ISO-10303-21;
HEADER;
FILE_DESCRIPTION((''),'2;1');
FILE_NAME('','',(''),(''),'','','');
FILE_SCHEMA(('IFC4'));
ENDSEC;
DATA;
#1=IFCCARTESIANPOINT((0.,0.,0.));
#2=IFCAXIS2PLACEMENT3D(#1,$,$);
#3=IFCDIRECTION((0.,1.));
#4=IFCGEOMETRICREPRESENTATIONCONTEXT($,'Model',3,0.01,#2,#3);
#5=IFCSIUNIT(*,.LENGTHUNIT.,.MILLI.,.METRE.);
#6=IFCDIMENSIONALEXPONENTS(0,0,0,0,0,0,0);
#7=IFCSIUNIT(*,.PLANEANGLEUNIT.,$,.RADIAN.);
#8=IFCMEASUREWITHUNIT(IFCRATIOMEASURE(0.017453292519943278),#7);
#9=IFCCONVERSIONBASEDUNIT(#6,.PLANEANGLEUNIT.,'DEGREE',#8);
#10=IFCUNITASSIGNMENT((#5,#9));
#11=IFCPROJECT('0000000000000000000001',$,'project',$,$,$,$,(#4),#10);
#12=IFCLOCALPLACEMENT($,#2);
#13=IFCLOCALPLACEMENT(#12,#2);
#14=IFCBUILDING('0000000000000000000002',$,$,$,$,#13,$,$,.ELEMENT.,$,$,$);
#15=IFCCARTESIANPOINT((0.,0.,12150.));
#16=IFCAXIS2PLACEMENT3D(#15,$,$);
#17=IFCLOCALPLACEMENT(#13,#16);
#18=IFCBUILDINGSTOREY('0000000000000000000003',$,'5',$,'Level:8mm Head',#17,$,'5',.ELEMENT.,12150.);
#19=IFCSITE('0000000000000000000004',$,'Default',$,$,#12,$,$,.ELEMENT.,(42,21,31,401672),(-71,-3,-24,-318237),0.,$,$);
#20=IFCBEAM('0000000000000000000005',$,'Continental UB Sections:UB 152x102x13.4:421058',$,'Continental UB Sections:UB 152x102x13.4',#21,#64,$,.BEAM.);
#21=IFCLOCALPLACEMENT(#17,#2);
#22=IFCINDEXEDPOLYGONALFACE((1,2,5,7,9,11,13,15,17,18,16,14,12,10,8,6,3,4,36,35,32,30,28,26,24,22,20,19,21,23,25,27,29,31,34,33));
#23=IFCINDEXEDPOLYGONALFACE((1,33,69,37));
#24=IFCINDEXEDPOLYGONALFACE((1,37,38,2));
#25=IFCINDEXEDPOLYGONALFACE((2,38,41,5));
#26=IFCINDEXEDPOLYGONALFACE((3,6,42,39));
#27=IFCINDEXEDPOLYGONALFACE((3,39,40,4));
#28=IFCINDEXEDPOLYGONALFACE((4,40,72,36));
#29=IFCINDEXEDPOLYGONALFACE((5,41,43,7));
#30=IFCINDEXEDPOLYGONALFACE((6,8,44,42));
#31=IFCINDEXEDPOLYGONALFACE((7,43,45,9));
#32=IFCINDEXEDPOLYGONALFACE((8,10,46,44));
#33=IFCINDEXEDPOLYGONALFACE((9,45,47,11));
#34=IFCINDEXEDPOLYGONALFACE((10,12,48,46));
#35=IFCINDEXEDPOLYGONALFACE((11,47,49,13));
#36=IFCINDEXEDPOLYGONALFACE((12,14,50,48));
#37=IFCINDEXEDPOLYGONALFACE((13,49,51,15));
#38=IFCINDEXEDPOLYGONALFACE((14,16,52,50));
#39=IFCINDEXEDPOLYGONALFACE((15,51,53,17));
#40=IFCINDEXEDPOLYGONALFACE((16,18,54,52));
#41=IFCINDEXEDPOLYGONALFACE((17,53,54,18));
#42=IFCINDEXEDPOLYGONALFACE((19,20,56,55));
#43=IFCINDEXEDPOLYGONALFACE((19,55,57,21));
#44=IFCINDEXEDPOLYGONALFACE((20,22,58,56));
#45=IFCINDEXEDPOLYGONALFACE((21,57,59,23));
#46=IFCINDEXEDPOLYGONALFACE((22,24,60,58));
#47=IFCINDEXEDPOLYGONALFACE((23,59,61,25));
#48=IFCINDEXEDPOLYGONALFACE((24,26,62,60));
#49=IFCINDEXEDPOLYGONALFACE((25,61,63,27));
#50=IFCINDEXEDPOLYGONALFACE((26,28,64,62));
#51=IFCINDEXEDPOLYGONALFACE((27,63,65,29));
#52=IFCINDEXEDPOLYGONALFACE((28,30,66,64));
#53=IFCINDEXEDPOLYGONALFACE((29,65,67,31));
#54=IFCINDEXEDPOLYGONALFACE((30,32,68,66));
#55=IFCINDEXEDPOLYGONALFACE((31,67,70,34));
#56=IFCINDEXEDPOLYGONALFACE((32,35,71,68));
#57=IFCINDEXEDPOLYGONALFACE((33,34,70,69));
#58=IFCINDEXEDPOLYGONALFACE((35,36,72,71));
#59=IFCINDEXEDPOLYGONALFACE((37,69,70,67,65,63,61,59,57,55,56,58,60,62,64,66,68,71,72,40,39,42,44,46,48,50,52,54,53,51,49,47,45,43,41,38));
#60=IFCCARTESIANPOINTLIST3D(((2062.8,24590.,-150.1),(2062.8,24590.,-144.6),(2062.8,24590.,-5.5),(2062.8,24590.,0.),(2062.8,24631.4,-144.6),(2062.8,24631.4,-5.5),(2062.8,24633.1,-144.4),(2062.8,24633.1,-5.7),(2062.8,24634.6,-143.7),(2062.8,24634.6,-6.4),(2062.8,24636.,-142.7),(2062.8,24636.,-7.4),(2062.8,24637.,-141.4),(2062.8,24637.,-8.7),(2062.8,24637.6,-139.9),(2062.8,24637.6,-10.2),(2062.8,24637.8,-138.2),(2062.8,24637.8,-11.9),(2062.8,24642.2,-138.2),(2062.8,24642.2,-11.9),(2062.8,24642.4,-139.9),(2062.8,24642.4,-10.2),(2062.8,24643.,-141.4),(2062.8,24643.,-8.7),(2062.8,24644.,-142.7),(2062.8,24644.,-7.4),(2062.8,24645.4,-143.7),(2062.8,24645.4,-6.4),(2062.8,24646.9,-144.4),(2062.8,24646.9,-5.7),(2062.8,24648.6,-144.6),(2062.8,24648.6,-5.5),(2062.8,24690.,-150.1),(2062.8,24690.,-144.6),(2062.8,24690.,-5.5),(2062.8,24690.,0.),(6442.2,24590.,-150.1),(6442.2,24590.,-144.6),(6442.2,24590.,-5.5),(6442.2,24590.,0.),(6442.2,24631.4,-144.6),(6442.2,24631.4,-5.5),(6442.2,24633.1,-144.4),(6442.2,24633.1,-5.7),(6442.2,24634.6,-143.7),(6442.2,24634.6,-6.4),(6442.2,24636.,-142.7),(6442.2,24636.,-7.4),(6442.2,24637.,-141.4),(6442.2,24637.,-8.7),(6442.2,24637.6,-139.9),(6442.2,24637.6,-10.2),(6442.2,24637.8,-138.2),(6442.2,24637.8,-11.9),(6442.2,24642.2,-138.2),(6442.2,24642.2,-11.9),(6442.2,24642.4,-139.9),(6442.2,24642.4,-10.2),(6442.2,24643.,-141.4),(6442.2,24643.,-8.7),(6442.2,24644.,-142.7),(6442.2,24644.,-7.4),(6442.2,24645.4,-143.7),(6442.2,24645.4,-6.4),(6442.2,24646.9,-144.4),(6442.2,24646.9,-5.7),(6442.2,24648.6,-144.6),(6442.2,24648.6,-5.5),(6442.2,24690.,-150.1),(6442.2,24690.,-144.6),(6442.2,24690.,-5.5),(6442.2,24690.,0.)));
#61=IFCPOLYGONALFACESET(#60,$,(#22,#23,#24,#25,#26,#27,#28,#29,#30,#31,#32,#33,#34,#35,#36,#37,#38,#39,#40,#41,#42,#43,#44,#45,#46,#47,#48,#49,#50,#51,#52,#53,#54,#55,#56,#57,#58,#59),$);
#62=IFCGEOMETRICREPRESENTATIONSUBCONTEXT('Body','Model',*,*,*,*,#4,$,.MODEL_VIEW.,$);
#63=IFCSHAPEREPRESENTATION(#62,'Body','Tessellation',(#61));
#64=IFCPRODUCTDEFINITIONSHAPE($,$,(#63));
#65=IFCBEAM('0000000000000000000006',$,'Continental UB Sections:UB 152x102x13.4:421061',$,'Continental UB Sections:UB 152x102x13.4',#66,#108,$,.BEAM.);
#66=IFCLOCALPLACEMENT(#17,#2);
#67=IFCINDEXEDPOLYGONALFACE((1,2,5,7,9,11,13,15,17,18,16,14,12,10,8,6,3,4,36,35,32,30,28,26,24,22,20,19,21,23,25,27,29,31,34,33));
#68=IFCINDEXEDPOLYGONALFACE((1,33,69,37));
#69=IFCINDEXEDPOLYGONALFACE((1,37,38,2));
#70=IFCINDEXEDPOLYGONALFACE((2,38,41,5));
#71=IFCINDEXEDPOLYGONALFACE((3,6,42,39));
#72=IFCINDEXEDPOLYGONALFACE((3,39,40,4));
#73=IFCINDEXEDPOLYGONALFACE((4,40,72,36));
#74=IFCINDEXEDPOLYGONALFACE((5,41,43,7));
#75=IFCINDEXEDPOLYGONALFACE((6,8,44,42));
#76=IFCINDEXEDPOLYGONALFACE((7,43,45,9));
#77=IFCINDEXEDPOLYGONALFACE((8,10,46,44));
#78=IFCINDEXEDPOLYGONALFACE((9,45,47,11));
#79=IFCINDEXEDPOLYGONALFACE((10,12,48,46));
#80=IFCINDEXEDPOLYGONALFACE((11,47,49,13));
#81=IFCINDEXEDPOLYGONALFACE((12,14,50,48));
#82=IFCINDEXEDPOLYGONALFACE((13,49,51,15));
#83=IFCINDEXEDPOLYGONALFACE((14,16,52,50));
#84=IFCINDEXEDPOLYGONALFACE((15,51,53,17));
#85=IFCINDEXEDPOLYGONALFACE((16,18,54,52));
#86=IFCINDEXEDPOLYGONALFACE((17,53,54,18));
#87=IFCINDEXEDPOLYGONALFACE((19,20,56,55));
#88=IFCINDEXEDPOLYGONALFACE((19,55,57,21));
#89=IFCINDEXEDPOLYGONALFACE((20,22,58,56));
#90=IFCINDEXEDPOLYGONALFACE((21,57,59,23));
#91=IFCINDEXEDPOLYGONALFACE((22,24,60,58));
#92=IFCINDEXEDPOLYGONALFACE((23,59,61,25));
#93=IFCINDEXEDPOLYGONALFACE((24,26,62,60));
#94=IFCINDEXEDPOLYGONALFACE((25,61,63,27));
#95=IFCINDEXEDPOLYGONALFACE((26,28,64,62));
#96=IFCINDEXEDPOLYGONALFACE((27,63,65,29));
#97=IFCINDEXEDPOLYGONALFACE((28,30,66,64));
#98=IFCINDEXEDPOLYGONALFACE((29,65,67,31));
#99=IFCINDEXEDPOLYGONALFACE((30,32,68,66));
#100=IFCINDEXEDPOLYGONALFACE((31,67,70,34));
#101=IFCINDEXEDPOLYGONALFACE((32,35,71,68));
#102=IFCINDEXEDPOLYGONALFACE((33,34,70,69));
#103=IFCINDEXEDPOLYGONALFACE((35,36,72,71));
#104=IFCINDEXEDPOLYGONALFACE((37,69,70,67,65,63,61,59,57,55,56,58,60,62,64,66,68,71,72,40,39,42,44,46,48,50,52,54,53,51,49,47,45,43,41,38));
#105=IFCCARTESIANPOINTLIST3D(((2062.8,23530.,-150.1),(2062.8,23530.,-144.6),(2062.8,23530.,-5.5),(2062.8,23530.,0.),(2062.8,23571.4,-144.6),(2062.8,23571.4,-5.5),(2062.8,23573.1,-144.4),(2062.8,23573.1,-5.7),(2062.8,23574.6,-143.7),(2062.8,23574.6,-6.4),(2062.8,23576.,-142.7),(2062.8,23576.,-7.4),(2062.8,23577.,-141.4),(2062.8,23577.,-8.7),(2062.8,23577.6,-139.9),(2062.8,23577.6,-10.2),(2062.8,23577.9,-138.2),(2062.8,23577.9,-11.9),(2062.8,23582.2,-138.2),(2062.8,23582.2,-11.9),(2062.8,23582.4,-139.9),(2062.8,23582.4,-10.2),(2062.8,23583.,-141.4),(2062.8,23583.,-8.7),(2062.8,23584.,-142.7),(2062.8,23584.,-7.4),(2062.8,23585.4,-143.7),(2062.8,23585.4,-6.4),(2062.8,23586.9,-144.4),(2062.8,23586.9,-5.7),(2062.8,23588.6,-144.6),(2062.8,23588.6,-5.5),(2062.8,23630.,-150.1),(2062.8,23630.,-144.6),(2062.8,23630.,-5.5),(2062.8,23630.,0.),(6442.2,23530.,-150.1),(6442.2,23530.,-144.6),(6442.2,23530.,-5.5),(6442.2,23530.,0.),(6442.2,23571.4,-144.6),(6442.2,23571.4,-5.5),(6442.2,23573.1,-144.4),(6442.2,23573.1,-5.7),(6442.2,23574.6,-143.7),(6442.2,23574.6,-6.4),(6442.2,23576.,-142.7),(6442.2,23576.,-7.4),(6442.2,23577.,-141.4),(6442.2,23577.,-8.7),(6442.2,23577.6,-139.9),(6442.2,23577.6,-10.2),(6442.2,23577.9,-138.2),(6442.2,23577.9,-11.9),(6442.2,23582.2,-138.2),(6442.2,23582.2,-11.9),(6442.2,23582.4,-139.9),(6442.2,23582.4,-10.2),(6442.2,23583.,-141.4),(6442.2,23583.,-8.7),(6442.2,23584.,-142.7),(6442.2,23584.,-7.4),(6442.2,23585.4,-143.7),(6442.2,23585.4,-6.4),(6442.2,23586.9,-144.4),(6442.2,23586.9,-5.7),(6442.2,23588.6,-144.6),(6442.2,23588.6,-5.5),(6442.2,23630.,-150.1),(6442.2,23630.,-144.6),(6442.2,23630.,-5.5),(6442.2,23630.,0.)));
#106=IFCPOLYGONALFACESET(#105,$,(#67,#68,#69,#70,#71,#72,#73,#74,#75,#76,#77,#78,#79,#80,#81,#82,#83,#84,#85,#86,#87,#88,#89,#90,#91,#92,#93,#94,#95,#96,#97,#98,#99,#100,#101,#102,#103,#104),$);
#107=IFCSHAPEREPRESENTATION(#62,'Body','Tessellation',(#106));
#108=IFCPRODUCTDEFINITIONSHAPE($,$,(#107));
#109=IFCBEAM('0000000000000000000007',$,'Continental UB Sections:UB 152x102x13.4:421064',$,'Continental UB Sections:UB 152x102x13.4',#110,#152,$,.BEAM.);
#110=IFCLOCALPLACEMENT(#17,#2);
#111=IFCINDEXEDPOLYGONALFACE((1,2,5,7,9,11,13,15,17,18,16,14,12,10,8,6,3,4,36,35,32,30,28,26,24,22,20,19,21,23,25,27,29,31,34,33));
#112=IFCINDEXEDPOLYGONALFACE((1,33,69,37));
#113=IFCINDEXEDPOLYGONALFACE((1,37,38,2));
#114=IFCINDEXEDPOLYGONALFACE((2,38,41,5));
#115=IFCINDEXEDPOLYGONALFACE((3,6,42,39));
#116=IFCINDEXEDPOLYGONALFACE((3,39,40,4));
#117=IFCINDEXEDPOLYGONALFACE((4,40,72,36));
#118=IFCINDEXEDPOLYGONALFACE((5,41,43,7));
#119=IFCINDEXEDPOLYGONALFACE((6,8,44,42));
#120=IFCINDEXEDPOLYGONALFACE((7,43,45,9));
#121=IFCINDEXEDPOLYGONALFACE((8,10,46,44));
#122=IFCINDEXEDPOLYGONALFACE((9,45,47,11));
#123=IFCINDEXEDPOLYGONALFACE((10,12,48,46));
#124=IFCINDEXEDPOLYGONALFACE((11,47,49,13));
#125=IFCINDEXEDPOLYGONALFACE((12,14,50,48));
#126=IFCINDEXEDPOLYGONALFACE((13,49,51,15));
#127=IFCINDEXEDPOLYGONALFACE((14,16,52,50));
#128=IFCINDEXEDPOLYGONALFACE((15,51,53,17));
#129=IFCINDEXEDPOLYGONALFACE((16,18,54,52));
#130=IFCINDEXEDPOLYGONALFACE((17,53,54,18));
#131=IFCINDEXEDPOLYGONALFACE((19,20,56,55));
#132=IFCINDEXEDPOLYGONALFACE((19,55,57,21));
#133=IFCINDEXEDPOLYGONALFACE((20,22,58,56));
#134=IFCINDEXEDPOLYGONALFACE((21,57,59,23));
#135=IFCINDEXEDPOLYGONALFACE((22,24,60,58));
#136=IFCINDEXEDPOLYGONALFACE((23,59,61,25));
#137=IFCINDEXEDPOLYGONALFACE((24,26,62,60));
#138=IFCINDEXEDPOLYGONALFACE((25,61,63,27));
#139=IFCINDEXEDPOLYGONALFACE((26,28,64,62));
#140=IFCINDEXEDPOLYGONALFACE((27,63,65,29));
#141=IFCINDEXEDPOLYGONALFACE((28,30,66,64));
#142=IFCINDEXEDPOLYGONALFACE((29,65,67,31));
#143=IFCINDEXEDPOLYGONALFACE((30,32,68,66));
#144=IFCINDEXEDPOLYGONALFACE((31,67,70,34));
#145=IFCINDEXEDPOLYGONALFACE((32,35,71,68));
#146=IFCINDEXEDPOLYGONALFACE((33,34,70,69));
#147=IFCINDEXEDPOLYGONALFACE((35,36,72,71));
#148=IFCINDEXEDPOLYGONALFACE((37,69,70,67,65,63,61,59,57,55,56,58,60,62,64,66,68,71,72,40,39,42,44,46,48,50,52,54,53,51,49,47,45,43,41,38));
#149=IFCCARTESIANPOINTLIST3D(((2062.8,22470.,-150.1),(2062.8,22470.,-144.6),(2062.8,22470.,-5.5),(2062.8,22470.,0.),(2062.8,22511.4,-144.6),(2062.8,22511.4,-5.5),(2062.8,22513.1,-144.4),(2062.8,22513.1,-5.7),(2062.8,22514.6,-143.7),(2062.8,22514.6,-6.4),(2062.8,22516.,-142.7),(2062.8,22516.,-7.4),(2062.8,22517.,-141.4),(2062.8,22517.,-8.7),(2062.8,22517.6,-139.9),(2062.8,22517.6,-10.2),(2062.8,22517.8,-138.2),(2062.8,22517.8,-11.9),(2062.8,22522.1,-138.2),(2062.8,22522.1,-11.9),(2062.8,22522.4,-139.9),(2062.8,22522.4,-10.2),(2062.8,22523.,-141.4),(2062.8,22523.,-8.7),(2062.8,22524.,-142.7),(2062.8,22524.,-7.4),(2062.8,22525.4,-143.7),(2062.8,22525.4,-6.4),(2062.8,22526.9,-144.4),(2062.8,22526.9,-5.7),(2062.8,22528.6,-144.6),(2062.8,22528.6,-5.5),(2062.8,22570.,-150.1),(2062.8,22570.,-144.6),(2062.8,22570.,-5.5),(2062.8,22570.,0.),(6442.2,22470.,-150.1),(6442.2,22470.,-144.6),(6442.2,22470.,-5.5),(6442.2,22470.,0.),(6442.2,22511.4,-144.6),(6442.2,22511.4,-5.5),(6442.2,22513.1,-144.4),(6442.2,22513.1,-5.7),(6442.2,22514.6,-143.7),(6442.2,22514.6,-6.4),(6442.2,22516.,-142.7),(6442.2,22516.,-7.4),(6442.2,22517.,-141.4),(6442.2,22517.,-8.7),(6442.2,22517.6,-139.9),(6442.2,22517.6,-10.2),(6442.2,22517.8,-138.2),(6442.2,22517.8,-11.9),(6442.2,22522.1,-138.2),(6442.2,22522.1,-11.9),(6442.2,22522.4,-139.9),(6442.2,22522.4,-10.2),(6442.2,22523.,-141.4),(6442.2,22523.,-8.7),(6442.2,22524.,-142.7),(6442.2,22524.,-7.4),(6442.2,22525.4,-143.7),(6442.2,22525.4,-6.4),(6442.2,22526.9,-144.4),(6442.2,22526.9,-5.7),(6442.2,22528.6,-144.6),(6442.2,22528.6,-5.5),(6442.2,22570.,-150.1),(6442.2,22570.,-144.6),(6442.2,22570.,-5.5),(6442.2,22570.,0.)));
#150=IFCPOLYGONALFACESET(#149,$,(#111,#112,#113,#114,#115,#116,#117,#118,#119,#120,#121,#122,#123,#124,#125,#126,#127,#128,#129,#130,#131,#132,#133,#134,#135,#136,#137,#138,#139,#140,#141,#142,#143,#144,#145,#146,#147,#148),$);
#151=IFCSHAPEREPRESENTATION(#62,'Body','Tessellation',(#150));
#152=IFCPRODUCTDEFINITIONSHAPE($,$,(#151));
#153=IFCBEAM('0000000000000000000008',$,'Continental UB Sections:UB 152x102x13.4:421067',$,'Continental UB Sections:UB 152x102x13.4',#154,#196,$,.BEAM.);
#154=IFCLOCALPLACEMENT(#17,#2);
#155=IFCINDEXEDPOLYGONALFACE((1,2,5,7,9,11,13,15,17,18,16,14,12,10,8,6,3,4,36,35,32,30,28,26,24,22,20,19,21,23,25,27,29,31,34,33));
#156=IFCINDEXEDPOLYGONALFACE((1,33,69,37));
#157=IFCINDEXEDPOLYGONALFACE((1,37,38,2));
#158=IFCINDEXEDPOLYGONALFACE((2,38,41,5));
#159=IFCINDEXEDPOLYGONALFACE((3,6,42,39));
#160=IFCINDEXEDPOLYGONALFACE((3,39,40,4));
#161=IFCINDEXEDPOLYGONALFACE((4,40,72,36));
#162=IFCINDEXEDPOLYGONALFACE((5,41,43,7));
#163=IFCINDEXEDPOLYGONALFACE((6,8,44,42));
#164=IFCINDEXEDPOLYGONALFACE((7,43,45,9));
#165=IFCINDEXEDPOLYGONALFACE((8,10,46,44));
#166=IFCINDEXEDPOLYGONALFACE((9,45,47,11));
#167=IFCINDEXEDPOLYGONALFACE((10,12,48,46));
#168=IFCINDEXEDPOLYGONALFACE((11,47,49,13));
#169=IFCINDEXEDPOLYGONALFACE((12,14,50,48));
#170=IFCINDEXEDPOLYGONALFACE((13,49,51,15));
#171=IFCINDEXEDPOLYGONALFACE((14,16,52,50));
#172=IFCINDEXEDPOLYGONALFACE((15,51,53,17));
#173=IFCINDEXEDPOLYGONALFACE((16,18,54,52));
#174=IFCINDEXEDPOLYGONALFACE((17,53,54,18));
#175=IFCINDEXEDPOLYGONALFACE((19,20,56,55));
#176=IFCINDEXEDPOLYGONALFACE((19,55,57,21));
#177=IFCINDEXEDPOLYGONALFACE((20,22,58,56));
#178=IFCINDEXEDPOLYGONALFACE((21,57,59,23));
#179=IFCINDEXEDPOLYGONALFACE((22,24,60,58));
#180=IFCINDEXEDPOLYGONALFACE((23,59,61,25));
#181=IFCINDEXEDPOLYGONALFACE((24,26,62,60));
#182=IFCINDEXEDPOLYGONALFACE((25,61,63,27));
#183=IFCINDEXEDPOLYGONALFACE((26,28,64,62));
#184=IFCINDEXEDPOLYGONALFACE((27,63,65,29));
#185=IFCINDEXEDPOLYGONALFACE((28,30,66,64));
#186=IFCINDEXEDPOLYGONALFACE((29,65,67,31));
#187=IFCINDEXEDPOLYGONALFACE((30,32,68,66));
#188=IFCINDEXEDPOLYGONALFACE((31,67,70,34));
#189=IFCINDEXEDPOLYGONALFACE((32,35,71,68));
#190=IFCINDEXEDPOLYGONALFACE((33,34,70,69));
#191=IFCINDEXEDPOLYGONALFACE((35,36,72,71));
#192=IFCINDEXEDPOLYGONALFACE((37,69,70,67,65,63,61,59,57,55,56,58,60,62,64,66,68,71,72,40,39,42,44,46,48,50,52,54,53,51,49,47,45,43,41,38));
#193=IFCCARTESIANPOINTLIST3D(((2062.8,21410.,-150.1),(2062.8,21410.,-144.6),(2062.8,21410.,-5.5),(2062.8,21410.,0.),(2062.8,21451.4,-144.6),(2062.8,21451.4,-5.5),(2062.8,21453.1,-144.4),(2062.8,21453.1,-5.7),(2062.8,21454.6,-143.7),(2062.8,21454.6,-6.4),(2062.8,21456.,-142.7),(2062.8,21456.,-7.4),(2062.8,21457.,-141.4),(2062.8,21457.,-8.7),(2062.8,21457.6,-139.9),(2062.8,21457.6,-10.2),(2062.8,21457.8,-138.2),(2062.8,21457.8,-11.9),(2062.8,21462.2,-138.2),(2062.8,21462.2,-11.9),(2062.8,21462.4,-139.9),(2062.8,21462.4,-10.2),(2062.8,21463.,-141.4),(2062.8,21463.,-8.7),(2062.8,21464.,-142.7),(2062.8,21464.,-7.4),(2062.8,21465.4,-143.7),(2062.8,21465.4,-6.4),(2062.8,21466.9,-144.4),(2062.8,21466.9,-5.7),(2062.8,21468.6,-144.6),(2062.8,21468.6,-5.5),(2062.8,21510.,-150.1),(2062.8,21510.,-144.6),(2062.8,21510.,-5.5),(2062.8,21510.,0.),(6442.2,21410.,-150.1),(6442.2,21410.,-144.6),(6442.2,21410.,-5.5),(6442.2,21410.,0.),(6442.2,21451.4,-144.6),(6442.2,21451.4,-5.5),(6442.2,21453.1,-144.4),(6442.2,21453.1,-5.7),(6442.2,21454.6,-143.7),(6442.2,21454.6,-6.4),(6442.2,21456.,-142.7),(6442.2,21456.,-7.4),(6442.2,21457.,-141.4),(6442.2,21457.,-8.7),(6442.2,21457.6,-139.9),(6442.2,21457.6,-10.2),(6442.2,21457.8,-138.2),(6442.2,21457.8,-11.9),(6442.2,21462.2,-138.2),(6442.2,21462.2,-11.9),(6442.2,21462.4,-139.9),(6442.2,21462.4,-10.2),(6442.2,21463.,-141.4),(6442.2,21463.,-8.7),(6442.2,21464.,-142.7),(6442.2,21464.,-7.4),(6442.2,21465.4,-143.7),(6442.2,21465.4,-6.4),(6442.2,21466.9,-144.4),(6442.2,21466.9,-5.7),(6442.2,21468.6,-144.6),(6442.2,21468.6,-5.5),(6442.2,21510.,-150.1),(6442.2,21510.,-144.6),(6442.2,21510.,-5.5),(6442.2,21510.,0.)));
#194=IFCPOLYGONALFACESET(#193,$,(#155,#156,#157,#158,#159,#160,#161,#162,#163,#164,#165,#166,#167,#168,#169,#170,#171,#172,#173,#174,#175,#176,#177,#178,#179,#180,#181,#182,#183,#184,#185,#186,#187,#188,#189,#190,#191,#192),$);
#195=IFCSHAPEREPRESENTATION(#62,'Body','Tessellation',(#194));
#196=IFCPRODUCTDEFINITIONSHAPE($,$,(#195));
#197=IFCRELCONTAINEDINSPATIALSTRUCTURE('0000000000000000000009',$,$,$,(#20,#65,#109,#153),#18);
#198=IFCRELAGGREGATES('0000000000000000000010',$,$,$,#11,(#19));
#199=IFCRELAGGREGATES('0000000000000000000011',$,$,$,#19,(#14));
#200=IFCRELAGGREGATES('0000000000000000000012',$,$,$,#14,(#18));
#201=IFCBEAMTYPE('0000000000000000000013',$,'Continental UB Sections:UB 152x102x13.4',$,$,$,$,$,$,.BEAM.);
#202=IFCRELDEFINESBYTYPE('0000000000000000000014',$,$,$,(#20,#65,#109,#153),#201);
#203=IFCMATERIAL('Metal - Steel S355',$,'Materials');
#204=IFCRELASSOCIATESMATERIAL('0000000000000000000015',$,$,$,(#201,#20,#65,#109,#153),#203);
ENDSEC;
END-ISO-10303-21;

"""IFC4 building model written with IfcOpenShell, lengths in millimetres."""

from ifc_helpers import new_model, entity, si_unit, converted_unit, direction, frame, origin, place, context, subcontext, project, spatial, line, arc, indexed_curve, outline, extrude, source, transform, mapped, material, type_object, type_shapes, element, save


model = new_model("IFC4")

# Units and contexts
model_context = context("Model", 3, precision=0.01, world=origin(), true_north=direction((0.0, 1.0)))
body_context = subcontext(model_context, "Body", "Model", "MODEL_VIEW")
ifc_project = project(units=[si_unit("LENGTHUNIT", "METRE", prefix="MILLI"), converted_unit("PLANEANGLEUNIT", "DEGREE", entity("IfcRatioMeasure", 0.017453292519943278), si_unit("PLANEANGLEUNIT", "RADIAN"), dimensions=[0, 0, 0, 0, 0, 0, 0])], contexts=[model_context])

# Site, building, storey
site_placement = place(None, origin())
site = spatial("IfcSite", under=ifc_project, at=site_placement, Name="Default", CompositionType="ELEMENT", RefLatitude=(42, 21, 31, 401672), RefLongitude=(-71, -3, -24, -318237), RefElevation=0.0)
building_placement = place(site_placement, origin())
building = spatial("IfcBuilding", under=site, at=building_placement, CompositionType="ELEMENT")
storey_placement = place(building_placement, frame((0.0, 0.0, 12150.0)))
storey = spatial("IfcBuildingStorey", under=building, at=storey_placement, Name="5", ObjectType="Level:8mm Head", LongName="5", CompositionType="ELEMENT", Elevation=12150.0)

# Beams
ifc_material = material(Name="Metal - Steel S355", Category="Materials")
beam_type_1 = type_object("IfcBeamType", Name="Continental UB Sections:UB 152x102x13.4", PredefinedType="BEAM", material=ifc_material)
shared_shape_1 = source(origin(), body_context, "Body", "SweptSolid", [
    extrude(outline(indexed_curve([(-75.0, -50.1), (-69.6, -50.1), (-69.6, -8.5), (-67.7, -4.0), (-63.2, -2.1), (63.1, -2.1), (67.7, -4.0), (69.5, -8.5), (69.5, -50.1), (75.1, -50.1), (75.1, 50.1), (69.5, 50.1), (69.5, 8.6), (67.7, 4.0), (63.1, 2.2), (-63.2, 2.2), (-67.7, 4.0), (-69.6, 8.6), (-69.6, 50.0), (-75.0, 50.0)], segments=[line(1, 2, 3), arc(3, 4, 5), line(5, 6), arc(6, 7, 8), line(8, 9, 10, 11, 12, 13), arc(13, 14, 15), line(15, 16), arc(16, 17, 18), line(18, 19, 20, 1)], self_intersect=False)), frame((-2189.7, 0.0, 0.0), z_axis=(1.0, 0.0, 0.0), x_axis=(0.0, 0.0, -1.0)), (0.0, 0.0, 1.0), 4379.4),
])
type_shapes(beam_type_1, [shared_shape_1])
for number, where, name in (
    (1, (4252.5, 24640.0, -75.1), "Continental UB Sections:UB 152x102x13.4:421058"),
    (2, (4252.5, 23580.0, -75.1), "Continental UB Sections:UB 152x102x13.4:421061"),
    (3, (4252.5, 22520.0, -75.1), "Continental UB Sections:UB 152x102x13.4:421064"),
    (4, (4252.5, 21460.0, -75.1), "Continental UB Sections:UB 152x102x13.4:421067"),
):
    element("IfcBeam", number, at=place(storey_placement, frame(where)), inside=storey, type_object=beam_type_1, material=ifc_material, Name=name, ObjectType="Continental UB Sections:UB 152x102x13.4", PredefinedType="BEAM", context=body_context, shape_type="MappedRepresentation", body=[
        mapped(shared_shape_1, transform((0.0, 0.0, 0.0), scale=1.0)),
    ])

save(model, "model.ifc")
